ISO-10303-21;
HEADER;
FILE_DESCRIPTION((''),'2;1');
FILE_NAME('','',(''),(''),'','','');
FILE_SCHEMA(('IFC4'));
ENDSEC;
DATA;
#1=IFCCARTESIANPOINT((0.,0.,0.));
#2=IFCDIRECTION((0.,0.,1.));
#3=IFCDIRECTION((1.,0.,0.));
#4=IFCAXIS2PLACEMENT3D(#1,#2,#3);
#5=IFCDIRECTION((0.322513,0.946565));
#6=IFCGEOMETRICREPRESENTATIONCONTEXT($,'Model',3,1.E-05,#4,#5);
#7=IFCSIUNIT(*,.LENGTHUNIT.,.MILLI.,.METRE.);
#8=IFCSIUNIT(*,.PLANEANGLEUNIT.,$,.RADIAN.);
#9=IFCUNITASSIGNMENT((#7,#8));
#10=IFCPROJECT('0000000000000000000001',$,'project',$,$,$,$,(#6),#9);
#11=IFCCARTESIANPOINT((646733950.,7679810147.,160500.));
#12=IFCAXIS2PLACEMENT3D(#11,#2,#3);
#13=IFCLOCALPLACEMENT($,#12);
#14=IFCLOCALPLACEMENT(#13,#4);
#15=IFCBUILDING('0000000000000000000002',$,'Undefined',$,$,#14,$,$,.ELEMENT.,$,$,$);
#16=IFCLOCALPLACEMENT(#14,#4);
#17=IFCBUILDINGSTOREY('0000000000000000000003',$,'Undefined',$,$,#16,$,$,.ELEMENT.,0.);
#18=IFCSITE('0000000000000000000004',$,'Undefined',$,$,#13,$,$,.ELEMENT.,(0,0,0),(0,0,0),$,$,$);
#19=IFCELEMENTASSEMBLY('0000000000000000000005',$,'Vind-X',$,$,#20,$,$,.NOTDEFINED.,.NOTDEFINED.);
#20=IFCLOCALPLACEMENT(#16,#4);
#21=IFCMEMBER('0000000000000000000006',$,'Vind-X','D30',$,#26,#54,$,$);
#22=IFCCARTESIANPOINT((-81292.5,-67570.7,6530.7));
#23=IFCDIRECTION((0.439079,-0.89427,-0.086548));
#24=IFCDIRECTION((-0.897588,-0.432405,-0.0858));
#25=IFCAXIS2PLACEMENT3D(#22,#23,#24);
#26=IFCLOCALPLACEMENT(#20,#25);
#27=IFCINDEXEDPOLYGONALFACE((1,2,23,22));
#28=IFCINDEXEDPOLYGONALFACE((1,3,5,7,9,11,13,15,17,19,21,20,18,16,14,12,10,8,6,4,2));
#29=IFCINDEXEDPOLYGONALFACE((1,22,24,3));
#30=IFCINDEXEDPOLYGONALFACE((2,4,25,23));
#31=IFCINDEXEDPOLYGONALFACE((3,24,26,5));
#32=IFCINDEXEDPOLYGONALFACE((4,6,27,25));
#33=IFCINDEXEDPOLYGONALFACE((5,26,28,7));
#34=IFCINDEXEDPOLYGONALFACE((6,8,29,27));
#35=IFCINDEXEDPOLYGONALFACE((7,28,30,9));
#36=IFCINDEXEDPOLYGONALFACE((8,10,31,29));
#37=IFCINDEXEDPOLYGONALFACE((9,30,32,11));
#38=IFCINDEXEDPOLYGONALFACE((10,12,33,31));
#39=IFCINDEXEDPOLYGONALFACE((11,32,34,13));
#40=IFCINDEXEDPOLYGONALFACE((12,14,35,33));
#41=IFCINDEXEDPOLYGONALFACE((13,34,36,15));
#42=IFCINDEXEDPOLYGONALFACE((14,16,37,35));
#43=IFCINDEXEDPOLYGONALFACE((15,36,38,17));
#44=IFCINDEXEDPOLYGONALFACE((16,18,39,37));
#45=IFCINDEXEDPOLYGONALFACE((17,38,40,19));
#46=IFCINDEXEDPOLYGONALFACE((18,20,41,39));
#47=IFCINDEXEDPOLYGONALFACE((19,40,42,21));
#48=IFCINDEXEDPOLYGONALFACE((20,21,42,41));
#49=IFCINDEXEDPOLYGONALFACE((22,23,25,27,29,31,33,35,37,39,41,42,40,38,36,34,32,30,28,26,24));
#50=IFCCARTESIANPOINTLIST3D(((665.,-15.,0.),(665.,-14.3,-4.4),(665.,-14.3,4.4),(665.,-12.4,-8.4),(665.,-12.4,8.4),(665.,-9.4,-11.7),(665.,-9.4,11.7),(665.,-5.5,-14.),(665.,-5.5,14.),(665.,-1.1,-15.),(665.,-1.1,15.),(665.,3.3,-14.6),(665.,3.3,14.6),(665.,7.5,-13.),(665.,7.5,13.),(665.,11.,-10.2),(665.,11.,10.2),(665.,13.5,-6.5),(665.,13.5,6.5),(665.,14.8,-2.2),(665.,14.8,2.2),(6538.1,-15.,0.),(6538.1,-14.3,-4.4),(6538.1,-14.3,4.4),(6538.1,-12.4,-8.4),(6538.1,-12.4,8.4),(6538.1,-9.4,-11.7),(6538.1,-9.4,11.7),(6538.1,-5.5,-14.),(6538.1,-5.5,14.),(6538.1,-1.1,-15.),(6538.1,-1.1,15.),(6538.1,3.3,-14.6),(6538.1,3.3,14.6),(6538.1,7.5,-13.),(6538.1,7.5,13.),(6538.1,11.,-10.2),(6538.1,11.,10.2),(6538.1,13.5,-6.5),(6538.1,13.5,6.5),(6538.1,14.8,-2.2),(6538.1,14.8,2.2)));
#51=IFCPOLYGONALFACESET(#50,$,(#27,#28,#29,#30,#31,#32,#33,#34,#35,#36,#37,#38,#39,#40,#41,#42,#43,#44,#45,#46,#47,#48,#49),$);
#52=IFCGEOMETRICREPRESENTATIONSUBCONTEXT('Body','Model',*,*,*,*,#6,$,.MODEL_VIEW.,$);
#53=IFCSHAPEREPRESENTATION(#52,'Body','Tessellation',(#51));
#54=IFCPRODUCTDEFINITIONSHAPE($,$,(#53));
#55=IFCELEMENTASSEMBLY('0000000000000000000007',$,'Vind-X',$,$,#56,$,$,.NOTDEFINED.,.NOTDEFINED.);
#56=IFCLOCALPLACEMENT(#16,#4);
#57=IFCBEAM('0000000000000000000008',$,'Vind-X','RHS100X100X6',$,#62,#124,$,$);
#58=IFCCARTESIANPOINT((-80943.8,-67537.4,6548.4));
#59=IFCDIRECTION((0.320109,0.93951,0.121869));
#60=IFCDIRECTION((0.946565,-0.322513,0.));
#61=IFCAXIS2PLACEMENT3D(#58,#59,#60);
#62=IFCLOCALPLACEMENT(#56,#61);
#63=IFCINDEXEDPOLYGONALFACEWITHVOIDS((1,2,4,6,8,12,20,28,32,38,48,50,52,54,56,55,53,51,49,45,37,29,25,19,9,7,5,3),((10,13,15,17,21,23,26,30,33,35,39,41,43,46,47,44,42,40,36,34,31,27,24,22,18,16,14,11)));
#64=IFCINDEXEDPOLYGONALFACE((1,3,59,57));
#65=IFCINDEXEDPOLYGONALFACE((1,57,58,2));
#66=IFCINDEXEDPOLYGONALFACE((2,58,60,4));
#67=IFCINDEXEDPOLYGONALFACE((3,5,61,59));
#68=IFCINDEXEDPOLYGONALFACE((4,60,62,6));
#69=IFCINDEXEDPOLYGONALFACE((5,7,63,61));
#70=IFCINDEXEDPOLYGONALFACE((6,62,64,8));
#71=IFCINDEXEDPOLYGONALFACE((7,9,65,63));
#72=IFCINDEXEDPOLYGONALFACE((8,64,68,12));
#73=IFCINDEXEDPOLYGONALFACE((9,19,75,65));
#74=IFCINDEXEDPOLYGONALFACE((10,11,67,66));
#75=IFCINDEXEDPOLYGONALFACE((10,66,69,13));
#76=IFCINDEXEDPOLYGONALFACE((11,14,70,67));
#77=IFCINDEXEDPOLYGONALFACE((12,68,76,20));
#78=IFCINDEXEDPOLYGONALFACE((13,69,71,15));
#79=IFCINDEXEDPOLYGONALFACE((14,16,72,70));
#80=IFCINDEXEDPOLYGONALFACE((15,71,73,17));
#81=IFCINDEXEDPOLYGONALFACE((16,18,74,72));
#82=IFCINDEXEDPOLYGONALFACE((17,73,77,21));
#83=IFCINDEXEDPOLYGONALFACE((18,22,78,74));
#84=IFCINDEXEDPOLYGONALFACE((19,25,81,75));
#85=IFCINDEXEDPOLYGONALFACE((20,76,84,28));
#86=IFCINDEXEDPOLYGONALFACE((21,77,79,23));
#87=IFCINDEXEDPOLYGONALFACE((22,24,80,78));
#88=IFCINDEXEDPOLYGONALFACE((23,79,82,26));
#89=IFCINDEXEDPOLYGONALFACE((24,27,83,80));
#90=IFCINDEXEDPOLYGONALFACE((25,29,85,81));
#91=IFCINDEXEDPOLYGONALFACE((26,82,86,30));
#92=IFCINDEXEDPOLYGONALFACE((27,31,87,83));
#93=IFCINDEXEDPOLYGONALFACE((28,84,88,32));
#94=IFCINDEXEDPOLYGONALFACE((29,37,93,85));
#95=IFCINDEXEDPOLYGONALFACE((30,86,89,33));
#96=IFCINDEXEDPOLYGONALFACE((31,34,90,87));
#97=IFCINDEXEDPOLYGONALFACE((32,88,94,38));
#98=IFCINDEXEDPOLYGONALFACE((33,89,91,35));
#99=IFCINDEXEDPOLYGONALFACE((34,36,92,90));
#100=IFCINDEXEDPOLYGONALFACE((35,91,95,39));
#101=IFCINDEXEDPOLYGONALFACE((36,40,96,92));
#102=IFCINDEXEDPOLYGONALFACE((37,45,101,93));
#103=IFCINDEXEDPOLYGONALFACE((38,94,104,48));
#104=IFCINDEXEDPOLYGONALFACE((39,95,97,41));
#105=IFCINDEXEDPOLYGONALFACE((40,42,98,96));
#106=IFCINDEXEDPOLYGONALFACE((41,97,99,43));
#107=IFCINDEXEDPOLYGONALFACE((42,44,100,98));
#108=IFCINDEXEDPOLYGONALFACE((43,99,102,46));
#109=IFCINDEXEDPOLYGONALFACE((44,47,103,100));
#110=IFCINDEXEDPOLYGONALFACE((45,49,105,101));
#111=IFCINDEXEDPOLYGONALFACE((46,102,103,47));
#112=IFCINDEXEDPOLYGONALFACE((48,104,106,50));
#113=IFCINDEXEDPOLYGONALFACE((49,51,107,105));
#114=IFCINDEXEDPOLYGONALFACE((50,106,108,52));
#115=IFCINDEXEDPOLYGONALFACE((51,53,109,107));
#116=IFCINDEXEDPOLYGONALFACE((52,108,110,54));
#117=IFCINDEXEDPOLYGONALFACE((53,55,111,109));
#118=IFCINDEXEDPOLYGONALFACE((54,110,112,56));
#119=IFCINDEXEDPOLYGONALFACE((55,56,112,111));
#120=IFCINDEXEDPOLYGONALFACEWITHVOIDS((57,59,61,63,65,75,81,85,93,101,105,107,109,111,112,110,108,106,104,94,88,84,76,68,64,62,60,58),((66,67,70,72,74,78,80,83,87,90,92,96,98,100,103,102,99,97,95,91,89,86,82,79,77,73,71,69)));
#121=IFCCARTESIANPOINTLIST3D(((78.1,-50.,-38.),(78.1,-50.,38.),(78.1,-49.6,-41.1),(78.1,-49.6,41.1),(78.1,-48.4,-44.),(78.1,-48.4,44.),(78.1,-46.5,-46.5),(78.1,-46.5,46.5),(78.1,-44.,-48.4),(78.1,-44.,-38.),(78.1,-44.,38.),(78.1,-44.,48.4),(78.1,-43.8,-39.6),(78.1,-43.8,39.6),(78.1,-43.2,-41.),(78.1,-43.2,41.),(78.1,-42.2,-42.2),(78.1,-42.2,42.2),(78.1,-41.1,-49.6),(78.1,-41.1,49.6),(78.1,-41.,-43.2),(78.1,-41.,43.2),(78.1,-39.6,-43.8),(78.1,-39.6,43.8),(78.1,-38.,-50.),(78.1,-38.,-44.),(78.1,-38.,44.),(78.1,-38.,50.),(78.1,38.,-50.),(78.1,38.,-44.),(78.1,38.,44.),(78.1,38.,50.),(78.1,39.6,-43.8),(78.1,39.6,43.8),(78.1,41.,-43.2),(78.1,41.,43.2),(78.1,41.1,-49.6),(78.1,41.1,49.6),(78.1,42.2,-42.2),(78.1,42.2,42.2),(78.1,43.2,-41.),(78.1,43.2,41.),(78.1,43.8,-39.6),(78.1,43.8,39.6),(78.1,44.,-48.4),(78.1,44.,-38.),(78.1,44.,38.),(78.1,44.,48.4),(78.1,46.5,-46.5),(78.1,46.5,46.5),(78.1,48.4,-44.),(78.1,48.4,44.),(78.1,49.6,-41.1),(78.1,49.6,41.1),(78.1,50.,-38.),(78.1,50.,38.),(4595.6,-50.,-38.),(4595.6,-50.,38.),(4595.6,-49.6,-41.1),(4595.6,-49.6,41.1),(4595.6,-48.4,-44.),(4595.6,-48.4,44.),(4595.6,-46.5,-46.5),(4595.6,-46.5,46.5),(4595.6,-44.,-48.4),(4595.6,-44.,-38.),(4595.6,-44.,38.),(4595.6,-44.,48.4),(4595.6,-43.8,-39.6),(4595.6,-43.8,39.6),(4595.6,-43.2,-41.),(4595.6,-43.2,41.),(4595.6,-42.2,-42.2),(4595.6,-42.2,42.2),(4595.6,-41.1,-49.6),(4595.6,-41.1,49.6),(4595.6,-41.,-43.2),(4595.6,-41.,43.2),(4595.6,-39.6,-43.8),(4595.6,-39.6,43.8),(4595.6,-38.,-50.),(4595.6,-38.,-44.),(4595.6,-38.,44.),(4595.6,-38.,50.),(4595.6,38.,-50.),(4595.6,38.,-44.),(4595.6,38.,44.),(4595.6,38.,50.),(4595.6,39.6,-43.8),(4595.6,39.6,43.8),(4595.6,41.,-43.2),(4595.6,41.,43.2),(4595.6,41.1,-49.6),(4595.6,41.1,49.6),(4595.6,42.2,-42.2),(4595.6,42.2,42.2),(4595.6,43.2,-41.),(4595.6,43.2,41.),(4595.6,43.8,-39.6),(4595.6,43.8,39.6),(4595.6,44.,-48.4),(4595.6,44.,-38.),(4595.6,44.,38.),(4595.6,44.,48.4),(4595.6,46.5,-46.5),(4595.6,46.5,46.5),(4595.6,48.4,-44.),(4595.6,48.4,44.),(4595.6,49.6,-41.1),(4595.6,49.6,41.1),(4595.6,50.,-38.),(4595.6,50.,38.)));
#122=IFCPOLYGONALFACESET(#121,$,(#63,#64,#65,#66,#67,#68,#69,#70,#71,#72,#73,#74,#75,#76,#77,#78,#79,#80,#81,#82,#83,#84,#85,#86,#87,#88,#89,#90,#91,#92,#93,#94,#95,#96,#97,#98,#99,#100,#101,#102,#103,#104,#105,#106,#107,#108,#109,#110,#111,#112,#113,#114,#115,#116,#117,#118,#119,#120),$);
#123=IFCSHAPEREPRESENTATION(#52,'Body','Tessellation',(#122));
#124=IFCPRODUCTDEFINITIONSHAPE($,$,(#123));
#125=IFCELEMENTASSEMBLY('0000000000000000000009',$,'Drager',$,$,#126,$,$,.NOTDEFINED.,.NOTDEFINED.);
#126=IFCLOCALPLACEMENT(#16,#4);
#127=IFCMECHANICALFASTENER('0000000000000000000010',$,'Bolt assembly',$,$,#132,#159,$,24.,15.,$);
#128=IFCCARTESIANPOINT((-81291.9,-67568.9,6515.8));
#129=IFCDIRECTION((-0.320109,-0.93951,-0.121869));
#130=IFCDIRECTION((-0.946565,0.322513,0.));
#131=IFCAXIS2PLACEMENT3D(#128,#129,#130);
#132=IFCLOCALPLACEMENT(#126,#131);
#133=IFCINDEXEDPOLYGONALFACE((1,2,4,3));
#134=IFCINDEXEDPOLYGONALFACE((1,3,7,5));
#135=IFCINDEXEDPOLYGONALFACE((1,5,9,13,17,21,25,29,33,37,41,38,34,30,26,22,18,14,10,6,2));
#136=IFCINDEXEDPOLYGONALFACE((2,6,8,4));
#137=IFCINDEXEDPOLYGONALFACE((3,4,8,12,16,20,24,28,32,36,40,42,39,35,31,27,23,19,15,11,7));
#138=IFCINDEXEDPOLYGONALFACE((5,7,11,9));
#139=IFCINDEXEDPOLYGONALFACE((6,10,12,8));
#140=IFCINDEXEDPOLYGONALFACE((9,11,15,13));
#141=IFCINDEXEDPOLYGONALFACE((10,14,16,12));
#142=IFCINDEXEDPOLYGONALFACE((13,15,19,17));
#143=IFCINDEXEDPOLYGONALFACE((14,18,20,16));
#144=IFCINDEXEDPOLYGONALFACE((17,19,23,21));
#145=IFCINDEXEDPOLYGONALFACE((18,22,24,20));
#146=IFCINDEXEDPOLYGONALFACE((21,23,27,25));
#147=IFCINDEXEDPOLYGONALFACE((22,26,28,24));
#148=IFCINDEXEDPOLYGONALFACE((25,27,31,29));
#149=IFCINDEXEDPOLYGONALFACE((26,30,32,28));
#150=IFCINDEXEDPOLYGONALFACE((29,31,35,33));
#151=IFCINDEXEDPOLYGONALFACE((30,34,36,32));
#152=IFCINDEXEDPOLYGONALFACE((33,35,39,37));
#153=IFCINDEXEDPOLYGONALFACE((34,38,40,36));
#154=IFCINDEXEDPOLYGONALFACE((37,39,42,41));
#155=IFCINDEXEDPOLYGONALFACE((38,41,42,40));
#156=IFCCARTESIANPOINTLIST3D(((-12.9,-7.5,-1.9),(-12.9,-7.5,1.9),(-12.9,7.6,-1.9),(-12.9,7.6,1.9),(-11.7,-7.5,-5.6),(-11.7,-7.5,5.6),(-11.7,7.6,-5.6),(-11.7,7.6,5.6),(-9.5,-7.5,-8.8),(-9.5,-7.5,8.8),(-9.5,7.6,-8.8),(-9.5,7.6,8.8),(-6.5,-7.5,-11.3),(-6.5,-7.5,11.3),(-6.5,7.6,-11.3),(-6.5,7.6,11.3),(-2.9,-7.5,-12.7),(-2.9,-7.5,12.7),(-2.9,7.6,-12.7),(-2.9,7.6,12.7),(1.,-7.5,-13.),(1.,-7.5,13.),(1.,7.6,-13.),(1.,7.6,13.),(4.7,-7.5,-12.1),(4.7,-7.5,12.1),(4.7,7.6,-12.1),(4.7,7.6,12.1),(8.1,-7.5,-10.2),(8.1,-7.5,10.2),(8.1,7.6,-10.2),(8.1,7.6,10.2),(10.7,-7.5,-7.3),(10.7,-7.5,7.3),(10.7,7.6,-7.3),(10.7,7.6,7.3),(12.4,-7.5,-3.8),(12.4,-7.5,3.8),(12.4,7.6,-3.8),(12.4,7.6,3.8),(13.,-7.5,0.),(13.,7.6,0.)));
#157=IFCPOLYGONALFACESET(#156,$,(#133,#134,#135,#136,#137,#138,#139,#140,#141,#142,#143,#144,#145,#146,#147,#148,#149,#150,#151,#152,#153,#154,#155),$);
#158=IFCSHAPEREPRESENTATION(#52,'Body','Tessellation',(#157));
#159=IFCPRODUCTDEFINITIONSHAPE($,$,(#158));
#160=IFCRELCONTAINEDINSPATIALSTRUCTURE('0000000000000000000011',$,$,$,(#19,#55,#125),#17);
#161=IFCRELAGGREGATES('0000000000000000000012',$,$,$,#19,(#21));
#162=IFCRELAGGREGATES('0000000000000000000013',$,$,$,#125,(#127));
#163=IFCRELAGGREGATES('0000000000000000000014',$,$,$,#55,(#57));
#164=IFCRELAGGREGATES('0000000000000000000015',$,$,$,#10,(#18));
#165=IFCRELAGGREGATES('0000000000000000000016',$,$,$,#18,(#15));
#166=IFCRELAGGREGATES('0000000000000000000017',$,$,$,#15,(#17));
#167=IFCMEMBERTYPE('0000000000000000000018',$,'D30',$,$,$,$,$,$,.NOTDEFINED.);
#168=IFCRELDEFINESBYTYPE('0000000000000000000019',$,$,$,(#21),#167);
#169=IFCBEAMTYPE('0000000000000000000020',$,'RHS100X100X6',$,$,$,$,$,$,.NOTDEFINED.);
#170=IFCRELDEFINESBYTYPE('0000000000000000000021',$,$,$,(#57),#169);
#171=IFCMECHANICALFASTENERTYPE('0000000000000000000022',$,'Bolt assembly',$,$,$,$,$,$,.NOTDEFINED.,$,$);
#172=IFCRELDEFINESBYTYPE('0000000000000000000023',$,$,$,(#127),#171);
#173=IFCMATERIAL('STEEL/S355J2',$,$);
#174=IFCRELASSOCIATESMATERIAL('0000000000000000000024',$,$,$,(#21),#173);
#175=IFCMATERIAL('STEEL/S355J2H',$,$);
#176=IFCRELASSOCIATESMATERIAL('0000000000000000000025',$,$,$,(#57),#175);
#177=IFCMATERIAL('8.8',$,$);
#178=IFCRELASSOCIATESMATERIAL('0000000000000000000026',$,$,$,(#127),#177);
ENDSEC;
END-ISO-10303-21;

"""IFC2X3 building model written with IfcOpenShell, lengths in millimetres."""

from ifc_helpers import new_model, si_unit, direction, frame, origin_with_axes, origin_2d_with_axis, place, context, subcontext, project, spatial, hollow_rectangle, circle, extrude, clip, halfspace, source, transform, mapped, material, type_object, element, aggregate, save


model = new_model("IFC2X3")

# Units and contexts
model_context = context("Model", 3, precision=1e-05, world=origin_with_axes(), true_north=direction((0.322513, 0.946565)))
body_context = subcontext(model_context, "Body", "Model", "MODEL_VIEW")
ifc_project = project(units=[si_unit("LENGTHUNIT", "METRE", prefix="MILLI"), si_unit("PLANEANGLEUNIT", "RADIAN")], contexts=[model_context])

# Site, building, storey
site_placement = place(None, frame((646733950.0, 7679810147.0, 160500.0), z_axis=(0.0, 0.0, 1.0), x_axis=(1.0, 0.0, 0.0)))
site = spatial("IfcSite", under=ifc_project, at=site_placement, Name="Undefined", CompositionType="ELEMENT", RefLatitude=(0, 0, 0), RefLongitude=(0, 0, 0))
building_placement = place(site_placement, origin_with_axes())
building = spatial("IfcBuilding", under=site, at=building_placement, Name="Undefined", CompositionType="ELEMENT")
storey_placement = place(building_placement, origin_with_axes())
storey = spatial("IfcBuildingStorey", under=building, at=storey_placement, Name="Undefined", CompositionType="ELEMENT", Elevation=0.0)

# Shared definitions
ifc_material_1 = material(Name="STEEL/S355J2H")

# Element assembly, member
assembly_1_placement = place(storey_placement, origin_with_axes())
assembly_1 = element("IfcElementAssembly", 1, at=assembly_1_placement, inside=storey, Name="Vind-X", AssemblyPlace="NOTDEFINED", PredefinedType="NOTDEFINED")
ifc_material_2 = material(Name="STEEL/S355J2")
member_type = type_object("IfcMemberType", Name="D30", PredefinedType="NOTDEFINED")
member_placement = place(assembly_1_placement, frame((-81292.5, -67570.7, 6530.7), z_axis=(0.439079, -0.89427, -0.086548), x_axis=(-0.897588, -0.432405, -0.0858)))
member = element("IfcMember", 2, at=member_placement, type_object=member_type, material=ifc_material_2, Name="Vind-X", Description="D30", context=body_context, shape_type="Clipping", body=[
    clip(clip(extrude(circle(Radius=15.0, at=origin_2d_with_axis()), frame((6820.6, 0.0, 0.0), z_axis=(-1.0, 0.0, 0.0), x_axis=(0.0, -1.0, 0.0)), (0.0, 0.0, 1.0), 6820.6), halfspace(frame((6538.1, 6.0, 16.0), z_axis=(-1.0, 0.0, 0.0), x_axis=(0.0, -1.0, 0.0)), True)), halfspace(frame((665.0, 6.0, 10.2), z_axis=(-1.0, 0.0, 0.0), x_axis=(0.0, -1.0, 0.0)), False)),
])

# Element assembly, beam
beam_type_1 = type_object("IfcBeamType", Name="RHS100X100X6", PredefinedType="NOTDEFINED")
assembly_2_placement = place(storey_placement, origin_with_axes())
assembly_2 = element("IfcElementAssembly", 3, at=assembly_2_placement, inside=storey, Name="Vind-X", AssemblyPlace="NOTDEFINED", PredefinedType="NOTDEFINED")
beam_1_placement = place(assembly_2_placement, frame((-80943.8, -67537.4, 6548.4), z_axis=(0.320109, 0.93951, 0.121869), x_axis=(0.946565, -0.322513, 0.0)))
beam_1 = element("IfcBeam", 4, at=beam_1_placement, type_object=beam_type_1, material=ifc_material_1, Name="Vind-X", Description="RHS100X100X6", context=body_context, shape_type="Clipping", body=[
    clip(clip(extrude(hollow_rectangle(XDim=100.0, YDim=100.0, WallThickness=6.0, InnerFilletRadius=6.0, OuterFilletRadius=12.0, at=origin_2d_with_axis()), frame((4674.6, 0.0, 0.0), z_axis=(-1.0, 0.0, 0.0), x_axis=(0.0, -1.0, 0.0)), (0.0, 0.0, 1.0), 4674.6), halfspace(frame((4595.6, 22.5, 0.0), z_axis=(-1.0, 0.0, 0.0), x_axis=(0.0, 0.0, 1.0)), True)), halfspace(frame((78.1, 22.5, 0.0), z_axis=(1.0, 0.0, 0.0), x_axis=(0.0, 0.0, -1.0)), True)),
])

# Element assembly
assembly_3_placement = place(storey_placement, origin_with_axes())
assembly_3 = element("IfcElementAssembly", 5, at=assembly_3_placement, inside=storey, Name="Drager", AssemblyPlace="NOTDEFINED", PredefinedType="NOTDEFINED")

# Mechanical fastener
ifc_material_3 = material(Name="8.8")
mechanical_fastener_type = type_object("IfcMechanicalFastenerType", Name="Bolt assembly")
aggregate(assembly_1, [member])
shared_shape_1 = source(origin_with_axes(), body_context, "Body", "SweptSolid", [
    extrude(circle(Radius=13.0, at=origin_2d_with_axis()), frame((0.0, -7.5, 0.0), z_axis=(0.0, 1.0, 0.0), x_axis=(1.0, 0.0, 0.0)), (0.0, 0.0, 1.0), 15.1),
])
mechanical_fastener_1_placement = place(assembly_3_placement, frame((-81291.9, -67568.9, 6515.8), z_axis=(-0.320109, -0.93951, -0.121869), x_axis=(-0.946565, 0.322513, 0.0)))
mechanical_fastener_1 = element("IfcMechanicalFastener", 6, at=mechanical_fastener_1_placement, type_object=mechanical_fastener_type, material=ifc_material_3, Name="Bolt assembly", NominalDiameter=24.0, NominalLength=15.0, context=body_context, shape_type="MappedRepresentation", body=[
    mapped(shared_shape_1, transform((0.0, 0.0, 0.0))),
])
aggregate(assembly_3, [mechanical_fastener_1])
aggregate(assembly_2, [beam_1])

save(model, "model.ifc")
